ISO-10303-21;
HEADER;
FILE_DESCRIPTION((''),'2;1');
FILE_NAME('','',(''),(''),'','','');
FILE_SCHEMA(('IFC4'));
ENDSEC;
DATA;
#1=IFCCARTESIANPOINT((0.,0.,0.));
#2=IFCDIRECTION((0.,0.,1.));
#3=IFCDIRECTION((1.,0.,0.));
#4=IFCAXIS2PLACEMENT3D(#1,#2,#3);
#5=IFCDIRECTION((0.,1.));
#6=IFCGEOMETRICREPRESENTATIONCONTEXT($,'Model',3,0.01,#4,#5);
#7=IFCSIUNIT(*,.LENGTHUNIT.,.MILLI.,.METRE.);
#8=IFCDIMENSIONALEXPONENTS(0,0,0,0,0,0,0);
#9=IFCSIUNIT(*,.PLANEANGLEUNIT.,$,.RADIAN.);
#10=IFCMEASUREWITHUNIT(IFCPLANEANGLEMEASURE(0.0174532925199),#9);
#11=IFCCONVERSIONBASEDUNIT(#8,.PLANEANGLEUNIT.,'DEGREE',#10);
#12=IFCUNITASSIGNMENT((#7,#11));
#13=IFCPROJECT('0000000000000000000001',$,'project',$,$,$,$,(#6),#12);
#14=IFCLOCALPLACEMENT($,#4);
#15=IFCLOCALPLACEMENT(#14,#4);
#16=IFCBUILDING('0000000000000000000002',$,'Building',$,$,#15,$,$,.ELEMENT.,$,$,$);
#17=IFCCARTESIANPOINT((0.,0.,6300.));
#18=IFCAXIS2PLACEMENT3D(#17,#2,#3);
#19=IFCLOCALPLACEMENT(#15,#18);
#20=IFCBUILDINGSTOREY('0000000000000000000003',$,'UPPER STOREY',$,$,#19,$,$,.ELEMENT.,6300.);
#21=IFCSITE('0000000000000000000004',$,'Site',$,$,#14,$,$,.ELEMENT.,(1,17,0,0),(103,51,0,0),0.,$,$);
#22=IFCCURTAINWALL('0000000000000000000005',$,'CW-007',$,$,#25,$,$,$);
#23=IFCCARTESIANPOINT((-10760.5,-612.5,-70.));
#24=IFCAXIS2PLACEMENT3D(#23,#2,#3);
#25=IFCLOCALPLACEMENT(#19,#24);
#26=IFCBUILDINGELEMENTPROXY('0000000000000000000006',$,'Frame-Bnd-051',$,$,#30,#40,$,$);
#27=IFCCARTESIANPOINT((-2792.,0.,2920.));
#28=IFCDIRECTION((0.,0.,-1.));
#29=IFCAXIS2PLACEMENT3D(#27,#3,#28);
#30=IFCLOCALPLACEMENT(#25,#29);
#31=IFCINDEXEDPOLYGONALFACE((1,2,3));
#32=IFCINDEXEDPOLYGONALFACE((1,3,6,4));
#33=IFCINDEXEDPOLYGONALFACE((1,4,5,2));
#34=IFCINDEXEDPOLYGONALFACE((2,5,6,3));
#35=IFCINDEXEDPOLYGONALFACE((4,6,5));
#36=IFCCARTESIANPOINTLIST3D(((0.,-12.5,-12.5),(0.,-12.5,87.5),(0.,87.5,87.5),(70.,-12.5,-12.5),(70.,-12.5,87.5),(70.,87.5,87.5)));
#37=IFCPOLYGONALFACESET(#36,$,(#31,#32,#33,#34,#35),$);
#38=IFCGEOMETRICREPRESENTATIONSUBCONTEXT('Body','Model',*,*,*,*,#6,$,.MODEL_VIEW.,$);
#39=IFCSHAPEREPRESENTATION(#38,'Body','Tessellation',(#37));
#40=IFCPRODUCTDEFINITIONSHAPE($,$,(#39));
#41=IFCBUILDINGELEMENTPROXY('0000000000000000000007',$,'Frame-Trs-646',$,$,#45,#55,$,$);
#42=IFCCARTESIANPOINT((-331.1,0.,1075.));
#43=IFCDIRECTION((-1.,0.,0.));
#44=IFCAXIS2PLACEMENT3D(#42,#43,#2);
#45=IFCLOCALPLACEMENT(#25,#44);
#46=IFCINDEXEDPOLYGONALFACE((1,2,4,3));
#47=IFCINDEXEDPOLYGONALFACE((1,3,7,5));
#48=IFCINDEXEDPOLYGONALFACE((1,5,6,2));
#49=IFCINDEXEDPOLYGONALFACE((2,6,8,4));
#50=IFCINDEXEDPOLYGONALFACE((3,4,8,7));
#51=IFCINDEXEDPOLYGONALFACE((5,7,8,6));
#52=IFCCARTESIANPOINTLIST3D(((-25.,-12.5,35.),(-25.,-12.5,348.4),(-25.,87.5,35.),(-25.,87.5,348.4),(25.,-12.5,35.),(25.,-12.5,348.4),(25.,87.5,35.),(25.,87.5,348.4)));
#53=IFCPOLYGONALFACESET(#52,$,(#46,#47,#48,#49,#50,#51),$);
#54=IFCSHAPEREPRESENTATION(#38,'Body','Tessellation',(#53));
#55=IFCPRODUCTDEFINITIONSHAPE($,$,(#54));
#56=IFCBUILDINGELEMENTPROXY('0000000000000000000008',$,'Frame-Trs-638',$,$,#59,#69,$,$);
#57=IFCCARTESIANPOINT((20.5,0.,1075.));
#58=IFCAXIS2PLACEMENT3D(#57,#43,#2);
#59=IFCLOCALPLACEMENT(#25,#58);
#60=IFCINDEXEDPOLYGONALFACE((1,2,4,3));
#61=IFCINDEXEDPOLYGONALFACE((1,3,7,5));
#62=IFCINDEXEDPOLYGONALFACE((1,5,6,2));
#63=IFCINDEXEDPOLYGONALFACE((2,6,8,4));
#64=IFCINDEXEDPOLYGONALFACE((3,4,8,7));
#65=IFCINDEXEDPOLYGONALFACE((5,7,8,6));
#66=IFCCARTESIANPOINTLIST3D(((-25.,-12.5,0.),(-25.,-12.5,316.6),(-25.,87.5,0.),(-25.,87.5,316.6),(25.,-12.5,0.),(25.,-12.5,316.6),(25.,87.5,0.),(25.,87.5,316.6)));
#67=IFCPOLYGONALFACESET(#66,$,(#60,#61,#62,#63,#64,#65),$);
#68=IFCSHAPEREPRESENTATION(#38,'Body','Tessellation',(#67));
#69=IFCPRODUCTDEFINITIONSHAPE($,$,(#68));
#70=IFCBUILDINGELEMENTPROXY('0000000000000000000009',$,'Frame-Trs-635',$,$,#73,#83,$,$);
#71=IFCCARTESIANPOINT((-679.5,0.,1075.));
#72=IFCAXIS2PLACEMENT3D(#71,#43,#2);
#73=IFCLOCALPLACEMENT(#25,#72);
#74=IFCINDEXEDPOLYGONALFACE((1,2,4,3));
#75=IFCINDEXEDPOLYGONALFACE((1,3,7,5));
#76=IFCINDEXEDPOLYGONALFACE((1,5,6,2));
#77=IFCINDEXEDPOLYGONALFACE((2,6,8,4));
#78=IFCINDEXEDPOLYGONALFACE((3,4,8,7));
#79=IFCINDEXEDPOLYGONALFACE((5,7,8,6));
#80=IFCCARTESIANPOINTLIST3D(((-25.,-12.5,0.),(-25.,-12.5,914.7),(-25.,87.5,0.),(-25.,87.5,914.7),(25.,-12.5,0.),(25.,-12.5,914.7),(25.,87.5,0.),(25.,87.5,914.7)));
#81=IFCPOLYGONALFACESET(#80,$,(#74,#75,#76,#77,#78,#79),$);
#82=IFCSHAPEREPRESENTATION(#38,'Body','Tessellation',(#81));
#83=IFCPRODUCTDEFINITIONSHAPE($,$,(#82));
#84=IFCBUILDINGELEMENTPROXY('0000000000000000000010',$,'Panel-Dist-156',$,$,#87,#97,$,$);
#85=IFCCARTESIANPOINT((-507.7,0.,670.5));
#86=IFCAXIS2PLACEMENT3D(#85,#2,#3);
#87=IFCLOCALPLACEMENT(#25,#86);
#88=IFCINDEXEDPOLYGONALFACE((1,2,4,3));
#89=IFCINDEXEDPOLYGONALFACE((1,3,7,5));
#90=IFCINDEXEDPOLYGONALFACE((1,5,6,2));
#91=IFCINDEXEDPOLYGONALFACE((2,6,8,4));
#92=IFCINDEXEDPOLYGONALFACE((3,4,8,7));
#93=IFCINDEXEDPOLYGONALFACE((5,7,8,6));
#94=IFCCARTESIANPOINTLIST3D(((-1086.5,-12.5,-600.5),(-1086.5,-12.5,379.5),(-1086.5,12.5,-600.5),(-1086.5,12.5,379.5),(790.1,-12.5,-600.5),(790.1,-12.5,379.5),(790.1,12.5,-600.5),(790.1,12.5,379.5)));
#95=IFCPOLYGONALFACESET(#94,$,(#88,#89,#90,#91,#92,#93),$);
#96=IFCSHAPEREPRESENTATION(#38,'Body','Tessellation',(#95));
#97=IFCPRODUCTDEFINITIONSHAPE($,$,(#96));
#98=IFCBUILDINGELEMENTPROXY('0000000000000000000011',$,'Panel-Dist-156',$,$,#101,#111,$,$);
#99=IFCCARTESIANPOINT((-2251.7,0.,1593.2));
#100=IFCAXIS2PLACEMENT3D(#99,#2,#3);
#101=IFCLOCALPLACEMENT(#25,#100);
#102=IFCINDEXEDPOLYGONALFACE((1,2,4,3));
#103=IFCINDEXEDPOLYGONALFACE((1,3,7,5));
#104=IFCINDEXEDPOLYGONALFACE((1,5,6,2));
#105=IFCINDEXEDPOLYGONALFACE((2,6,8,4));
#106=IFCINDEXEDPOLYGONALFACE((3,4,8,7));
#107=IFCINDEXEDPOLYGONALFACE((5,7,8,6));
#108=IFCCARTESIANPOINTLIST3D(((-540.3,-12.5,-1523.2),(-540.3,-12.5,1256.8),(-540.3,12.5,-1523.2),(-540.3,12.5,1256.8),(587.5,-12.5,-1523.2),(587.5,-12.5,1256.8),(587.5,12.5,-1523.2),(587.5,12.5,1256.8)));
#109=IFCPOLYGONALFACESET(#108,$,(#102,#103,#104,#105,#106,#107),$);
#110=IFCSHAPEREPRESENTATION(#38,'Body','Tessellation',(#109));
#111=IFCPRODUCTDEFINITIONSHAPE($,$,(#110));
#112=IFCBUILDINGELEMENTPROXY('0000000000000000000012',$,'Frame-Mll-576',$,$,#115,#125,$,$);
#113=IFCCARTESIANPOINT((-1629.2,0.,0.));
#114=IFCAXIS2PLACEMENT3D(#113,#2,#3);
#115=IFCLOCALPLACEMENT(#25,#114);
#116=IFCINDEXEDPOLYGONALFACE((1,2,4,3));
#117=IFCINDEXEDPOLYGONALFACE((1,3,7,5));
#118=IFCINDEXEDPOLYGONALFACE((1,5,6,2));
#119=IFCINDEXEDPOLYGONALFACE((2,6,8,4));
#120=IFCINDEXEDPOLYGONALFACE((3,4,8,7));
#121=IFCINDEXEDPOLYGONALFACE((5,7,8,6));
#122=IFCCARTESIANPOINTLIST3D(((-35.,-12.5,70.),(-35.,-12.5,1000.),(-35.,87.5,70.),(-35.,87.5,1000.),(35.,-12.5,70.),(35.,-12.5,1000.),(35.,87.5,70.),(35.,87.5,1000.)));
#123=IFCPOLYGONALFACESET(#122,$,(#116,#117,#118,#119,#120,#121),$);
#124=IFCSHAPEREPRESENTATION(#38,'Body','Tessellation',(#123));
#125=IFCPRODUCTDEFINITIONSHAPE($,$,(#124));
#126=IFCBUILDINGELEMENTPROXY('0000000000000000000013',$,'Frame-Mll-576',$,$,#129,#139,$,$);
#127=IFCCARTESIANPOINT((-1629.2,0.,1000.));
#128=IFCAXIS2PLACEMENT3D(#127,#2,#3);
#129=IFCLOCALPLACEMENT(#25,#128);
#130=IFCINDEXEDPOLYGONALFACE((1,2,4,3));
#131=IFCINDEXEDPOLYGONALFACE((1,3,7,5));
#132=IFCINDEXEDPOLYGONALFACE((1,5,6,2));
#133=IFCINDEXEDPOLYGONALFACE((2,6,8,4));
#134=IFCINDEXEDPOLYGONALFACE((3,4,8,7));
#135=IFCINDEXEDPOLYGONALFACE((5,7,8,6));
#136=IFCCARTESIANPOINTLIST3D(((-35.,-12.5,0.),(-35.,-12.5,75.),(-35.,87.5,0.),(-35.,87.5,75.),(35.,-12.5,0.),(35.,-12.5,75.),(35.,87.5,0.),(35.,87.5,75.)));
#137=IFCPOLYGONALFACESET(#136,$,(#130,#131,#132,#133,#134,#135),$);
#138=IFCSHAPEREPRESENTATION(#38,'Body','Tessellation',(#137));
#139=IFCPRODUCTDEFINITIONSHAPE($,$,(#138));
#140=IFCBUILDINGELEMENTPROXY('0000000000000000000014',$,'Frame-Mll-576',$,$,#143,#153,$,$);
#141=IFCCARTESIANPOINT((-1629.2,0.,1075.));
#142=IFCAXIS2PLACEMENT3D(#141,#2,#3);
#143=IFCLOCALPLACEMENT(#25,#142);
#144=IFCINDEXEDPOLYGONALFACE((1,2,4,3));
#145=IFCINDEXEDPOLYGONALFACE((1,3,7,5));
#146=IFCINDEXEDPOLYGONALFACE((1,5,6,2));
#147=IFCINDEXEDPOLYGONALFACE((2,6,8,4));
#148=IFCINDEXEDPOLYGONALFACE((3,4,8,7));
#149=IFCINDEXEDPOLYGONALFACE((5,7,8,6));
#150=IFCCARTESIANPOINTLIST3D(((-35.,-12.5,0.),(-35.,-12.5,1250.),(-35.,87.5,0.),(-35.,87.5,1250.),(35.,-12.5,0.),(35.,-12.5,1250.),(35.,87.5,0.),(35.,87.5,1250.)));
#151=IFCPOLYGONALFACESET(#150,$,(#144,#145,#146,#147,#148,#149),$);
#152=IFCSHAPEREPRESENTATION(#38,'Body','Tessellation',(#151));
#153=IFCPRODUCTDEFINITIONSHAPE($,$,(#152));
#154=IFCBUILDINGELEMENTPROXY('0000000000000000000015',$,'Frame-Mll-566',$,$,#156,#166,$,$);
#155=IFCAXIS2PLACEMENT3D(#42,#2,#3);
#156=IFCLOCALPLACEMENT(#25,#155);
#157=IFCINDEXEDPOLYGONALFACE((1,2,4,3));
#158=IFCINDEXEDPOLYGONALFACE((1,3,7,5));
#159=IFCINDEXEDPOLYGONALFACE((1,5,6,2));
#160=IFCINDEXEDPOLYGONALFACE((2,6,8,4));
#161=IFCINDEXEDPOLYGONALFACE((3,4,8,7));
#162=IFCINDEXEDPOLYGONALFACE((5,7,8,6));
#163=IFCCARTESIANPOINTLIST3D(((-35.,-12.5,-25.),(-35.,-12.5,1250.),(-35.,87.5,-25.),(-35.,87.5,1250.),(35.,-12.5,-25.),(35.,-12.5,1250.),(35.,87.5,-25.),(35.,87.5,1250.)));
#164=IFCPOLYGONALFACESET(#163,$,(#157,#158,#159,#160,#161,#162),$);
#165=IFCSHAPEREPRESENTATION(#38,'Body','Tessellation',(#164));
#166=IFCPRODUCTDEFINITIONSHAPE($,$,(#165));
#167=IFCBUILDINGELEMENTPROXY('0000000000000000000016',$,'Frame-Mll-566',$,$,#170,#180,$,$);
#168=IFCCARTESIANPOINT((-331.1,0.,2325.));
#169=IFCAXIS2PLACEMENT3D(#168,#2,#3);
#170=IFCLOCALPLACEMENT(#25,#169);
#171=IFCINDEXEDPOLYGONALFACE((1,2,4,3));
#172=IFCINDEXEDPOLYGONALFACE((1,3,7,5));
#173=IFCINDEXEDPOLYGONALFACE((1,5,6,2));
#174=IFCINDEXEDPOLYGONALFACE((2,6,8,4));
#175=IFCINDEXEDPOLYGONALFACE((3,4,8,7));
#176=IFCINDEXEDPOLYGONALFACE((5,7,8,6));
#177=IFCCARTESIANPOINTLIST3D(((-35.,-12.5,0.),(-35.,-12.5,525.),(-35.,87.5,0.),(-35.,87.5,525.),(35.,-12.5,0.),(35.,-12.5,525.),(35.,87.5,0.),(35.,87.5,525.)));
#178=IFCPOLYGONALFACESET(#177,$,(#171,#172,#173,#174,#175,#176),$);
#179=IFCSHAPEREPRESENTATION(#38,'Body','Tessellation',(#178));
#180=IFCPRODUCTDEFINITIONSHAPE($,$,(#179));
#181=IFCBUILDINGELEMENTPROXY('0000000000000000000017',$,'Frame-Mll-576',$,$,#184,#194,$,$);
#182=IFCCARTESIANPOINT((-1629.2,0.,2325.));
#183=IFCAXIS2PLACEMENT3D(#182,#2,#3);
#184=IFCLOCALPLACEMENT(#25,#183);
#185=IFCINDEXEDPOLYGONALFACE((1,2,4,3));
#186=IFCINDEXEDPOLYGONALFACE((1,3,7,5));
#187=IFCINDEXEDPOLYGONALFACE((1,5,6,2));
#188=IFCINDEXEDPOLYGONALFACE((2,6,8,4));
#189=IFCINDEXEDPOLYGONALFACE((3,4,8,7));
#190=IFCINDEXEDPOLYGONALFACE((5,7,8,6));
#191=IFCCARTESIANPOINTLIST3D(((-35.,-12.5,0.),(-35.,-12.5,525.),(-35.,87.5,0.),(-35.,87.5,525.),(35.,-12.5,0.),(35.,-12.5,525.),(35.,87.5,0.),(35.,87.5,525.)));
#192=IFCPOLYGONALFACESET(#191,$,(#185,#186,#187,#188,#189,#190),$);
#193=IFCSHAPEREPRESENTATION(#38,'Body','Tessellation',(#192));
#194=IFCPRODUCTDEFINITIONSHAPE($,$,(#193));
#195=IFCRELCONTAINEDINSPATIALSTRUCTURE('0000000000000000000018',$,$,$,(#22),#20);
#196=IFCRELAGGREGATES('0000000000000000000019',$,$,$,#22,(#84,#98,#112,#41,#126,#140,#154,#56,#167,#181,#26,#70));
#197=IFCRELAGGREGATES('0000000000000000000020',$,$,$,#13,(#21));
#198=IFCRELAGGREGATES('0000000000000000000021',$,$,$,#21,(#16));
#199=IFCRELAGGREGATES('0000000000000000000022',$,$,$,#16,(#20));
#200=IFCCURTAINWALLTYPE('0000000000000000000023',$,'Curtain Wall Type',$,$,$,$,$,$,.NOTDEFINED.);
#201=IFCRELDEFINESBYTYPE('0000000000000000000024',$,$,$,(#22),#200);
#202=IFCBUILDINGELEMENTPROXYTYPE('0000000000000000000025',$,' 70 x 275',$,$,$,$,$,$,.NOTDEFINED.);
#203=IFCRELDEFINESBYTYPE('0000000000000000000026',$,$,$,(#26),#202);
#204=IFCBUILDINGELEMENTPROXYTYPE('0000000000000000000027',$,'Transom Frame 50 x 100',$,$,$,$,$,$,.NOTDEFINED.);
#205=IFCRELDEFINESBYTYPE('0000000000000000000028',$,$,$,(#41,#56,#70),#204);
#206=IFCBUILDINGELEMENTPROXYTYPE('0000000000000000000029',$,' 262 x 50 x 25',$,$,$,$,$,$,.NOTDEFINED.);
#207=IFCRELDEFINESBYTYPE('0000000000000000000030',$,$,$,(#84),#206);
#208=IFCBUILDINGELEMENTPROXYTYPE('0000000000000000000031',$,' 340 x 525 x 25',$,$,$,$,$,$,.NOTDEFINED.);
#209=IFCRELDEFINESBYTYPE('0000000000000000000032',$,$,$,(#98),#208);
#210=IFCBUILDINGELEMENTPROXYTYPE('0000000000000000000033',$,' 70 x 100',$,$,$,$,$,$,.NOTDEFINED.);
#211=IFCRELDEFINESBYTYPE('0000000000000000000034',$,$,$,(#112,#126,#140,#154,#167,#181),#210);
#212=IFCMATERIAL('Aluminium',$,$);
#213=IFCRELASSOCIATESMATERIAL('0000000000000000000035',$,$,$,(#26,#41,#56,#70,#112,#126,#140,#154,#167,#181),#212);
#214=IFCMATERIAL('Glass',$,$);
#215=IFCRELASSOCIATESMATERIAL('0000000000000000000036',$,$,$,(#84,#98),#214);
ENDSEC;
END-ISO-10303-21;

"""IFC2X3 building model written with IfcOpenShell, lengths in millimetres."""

from ifc_helpers import new_model, entity, si_unit, converted_unit, direction, frame, origin_with_axes, place, context, subcontext, project, spatial, polyline, outline, extrude, clip, halfspace, material, type_object, element, aggregate, save


model = new_model("IFC2X3")

# Units and contexts
model_context = context("Model", 3, precision=0.01, world=origin_with_axes(), true_north=direction((0.0, 1.0)))
body_context = subcontext(model_context, "Body", "Model", "MODEL_VIEW")
ifc_project = project(units=[si_unit("LENGTHUNIT", "METRE", prefix="MILLI"), converted_unit("PLANEANGLEUNIT", "DEGREE", entity("IfcPlaneAngleMeasure", 0.0174532925199), si_unit("PLANEANGLEUNIT", "RADIAN"), dimensions=[0, 0, 0, 0, 0, 0, 0])], contexts=[model_context])

# Site, building, storey
site_placement = place(None, origin_with_axes())
site = spatial("IfcSite", under=ifc_project, at=site_placement, Name="Site", CompositionType="ELEMENT", RefLatitude=(1, 17, 0, 0), RefLongitude=(103, 51, 0, 0), RefElevation=0.0)
building_placement = place(site_placement, origin_with_axes())
building = spatial("IfcBuilding", under=site, at=building_placement, Name="Building", CompositionType="ELEMENT")
storey_placement = place(building_placement, frame((0.0, 0.0, 6300.0), z_axis=(0.0, 0.0, 1.0), x_axis=(1.0, 0.0, 0.0)))
storey = spatial("IfcBuildingStorey", under=building, at=storey_placement, Name="UPPER STOREY", CompositionType="ELEMENT", Elevation=6300.0)

# Curtain wall, building element proxies
curtain_wall_type = type_object("IfcCurtainWallType", Name="Curtain Wall Type", PredefinedType="NOTDEFINED")
curtain_wall_placement = place(storey_placement, frame((-10760.5, -612.5, -70.0), z_axis=(0.0, 0.0, 1.0), x_axis=(1.0, 0.0, 0.0)))
curtain_wall = element("IfcCurtainWall", 1, at=curtain_wall_placement, inside=storey, type_object=curtain_wall_type, Name="CW-007")
ifc_material_1 = material(Name="Aluminium")
building_element_proxy_type_1 = type_object("IfcBuildingElementProxyType", Name=" 70 x 275", PredefinedType="NOTDEFINED")
proxy_1_placement = place(curtain_wall_placement, frame((-2792.0, 0.0, 2920.0), z_axis=(1.0, 0.0, 0.0), x_axis=(0.0, 0.0, -1.0)))
proxy_1 = element("IfcBuildingElementProxy", 2, at=proxy_1_placement, type_object=building_element_proxy_type_1, material=ifc_material_1, Name="Frame-Bnd-051", context=body_context, shape_type="Clipping", body=[
    clip(extrude(outline(polyline([(-87.5, 70.0), (-87.5, 0.0), (12.5, 0.0), (12.5, 70.0), (-87.5, 70.0)])), frame((0.0, 0.0, -12.5), z_axis=(0.0, 0.0, 1.0), x_axis=(0.0, -1.0, 0.0)), (0.0, 0.0, 1.0), 100.0), halfspace(frame((0.0, 0.0, 0.0), z_axis=(0.0, -0.707107, 0.707107), x_axis=(0.0, -0.707107, -0.707107)), True)),
])
building_element_proxy_type_2 = type_object("IfcBuildingElementProxyType", Name="Transom Frame 50 x 100", PredefinedType="NOTDEFINED")
proxy_2_placement = place(curtain_wall_placement, frame((-331.1, 0.0, 1075.0), z_axis=(-1.0, 0.0, 0.0), x_axis=(0.0, 0.0, 1.0)))
proxy_2 = element("IfcBuildingElementProxy", 3, at=proxy_2_placement, type_object=building_element_proxy_type_2, material=ifc_material_1, Name="Frame-Trs-646", context=body_context, shape_type="SweptSolid", body=[
    extrude(outline(polyline([(87.5, -25.0), (87.5, 25.0), (-12.5, 25.0), (-12.5, -25.0), (87.5, -25.0)])), frame((0.0, 0.0, 35.0), z_axis=(0.0, 0.0, 1.0), x_axis=(0.0, 1.0, 0.0)), (0.0, 0.0, 1.0), 313.4),
])
proxy_3_placement = place(curtain_wall_placement, frame((20.5, 0.0, 1075.0), z_axis=(-1.0, 0.0, 0.0), x_axis=(0.0, 0.0, 1.0)))
proxy_3 = element("IfcBuildingElementProxy", 4, at=proxy_3_placement, type_object=building_element_proxy_type_2, material=ifc_material_1, Name="Frame-Trs-638", context=body_context, shape_type="SweptSolid", body=[
    extrude(outline(polyline([(87.5, -25.0), (87.5, 25.0), (-12.5, 25.0), (-12.5, -25.0), (87.5, -25.0)])), frame((0.0, 0.0, 0.0), z_axis=(0.0, 0.0, 1.0), x_axis=(0.0, 1.0, 0.0)), (0.0, 0.0, 1.0), 316.6),
])
proxy_4_placement = place(curtain_wall_placement, frame((-679.5, 0.0, 1075.0), z_axis=(-1.0, 0.0, 0.0), x_axis=(0.0, 0.0, 1.0)))
proxy_4 = element("IfcBuildingElementProxy", 5, at=proxy_4_placement, type_object=building_element_proxy_type_2, material=ifc_material_1, Name="Frame-Trs-635", context=body_context, shape_type="SweptSolid", body=[
    extrude(outline(polyline([(87.5, -25.0), (87.5, 25.0), (-12.5, 25.0), (-12.5, -25.0), (87.5, -25.0)])), frame((0.0, 0.0, 0.0), z_axis=(0.0, 0.0, 1.0), x_axis=(0.0, 1.0, 0.0)), (0.0, 0.0, 1.0), 914.7),
])
ifc_material_2 = material(Name="Glass")
building_element_proxy_type_3 = type_object("IfcBuildingElementProxyType", Name=" 262 x 50 x 25", PredefinedType="NOTDEFINED")
proxy_5_placement = place(curtain_wall_placement, frame((-507.7, 0.0, 670.5), z_axis=(0.0, 0.0, 1.0), x_axis=(1.0, 0.0, 0.0)))
proxy_5 = element("IfcBuildingElementProxy", 6, at=proxy_5_placement, type_object=building_element_proxy_type_3, material=ifc_material_2, Name="Panel-Dist-156", context=body_context, shape_type="SweptSolid", body=[
    extrude(outline(polyline([(-1086.5, -379.5), (790.1, -379.5), (790.1, 600.5), (-1086.5, 600.5), (-1086.5, -379.5)])), frame((0.0, -12.5, 0.0), z_axis=(0.0, 1.0, 0.0), x_axis=(1.0, 0.0, 0.0)), (0.0, 0.0, 1.0), 25.0),
])
building_element_proxy_type_4 = type_object("IfcBuildingElementProxyType", Name=" 340 x 525 x 25", PredefinedType="NOTDEFINED")
proxy_6_placement = place(curtain_wall_placement, frame((-2251.7, 0.0, 1593.2), z_axis=(0.0, 0.0, 1.0), x_axis=(1.0, 0.0, 0.0)))
proxy_6 = element("IfcBuildingElementProxy", 7, at=proxy_6_placement, type_object=building_element_proxy_type_4, material=ifc_material_2, Name="Panel-Dist-156", context=body_context, shape_type="SweptSolid", body=[
    extrude(outline(polyline([(-540.3, -1256.8), (587.5, -1256.8), (587.5, 1523.2), (-540.3, 1523.2), (-540.3, -1256.8)])), frame((0.0, -12.5, 0.0), z_axis=(0.0, 1.0, 0.0), x_axis=(1.0, 0.0, 0.0)), (0.0, 0.0, 1.0), 25.0),
])
building_element_proxy_type_5 = type_object("IfcBuildingElementProxyType", Name=" 70 x 100", PredefinedType="NOTDEFINED")
proxy_7_placement = place(curtain_wall_placement, frame((-1629.2, 0.0, 0.0), z_axis=(0.0, 0.0, 1.0), x_axis=(1.0, 0.0, 0.0)))
proxy_7 = element("IfcBuildingElementProxy", 8, at=proxy_7_placement, type_object=building_element_proxy_type_5, material=ifc_material_1, Name="Frame-Mll-576", context=body_context, shape_type="SweptSolid", body=[
    extrude(outline(polyline([(35.0, 87.5), (-35.0, 87.5), (-35.0, -12.5), (35.0, -12.5), (35.0, 87.5)])), frame((0.0, 0.0, 70.0), z_axis=(0.0, 0.0, 1.0), x_axis=(1.0, 0.0, 0.0)), (0.0, 0.0, 1.0), 930.0),
])
proxy_8_placement = place(curtain_wall_placement, frame((-1629.2, 0.0, 1000.0), z_axis=(0.0, 0.0, 1.0), x_axis=(1.0, 0.0, 0.0)))
proxy_8 = element("IfcBuildingElementProxy", 9, at=proxy_8_placement, type_object=building_element_proxy_type_5, material=ifc_material_1, Name="Frame-Mll-576", context=body_context, shape_type="SweptSolid", body=[
    extrude(outline(polyline([(35.0, 87.5), (-35.0, 87.5), (-35.0, -12.5), (35.0, -12.5), (35.0, 87.5)])), frame((0.0, 0.0, 0.0), z_axis=(0.0, 0.0, 1.0), x_axis=(1.0, 0.0, 0.0)), (0.0, 0.0, 1.0), 75.0),
])
proxy_9_placement = place(curtain_wall_placement, frame((-1629.2, 0.0, 1075.0), z_axis=(0.0, 0.0, 1.0), x_axis=(1.0, 0.0, 0.0)))
proxy_9 = element("IfcBuildingElementProxy", 10, at=proxy_9_placement, type_object=building_element_proxy_type_5, material=ifc_material_1, Name="Frame-Mll-576", context=body_context, shape_type="SweptSolid", body=[
    extrude(outline(polyline([(35.0, 87.5), (-35.0, 87.5), (-35.0, -12.5), (35.0, -12.5), (35.0, 87.5)])), frame((0.0, 0.0, 0.0), z_axis=(0.0, 0.0, 1.0), x_axis=(1.0, 0.0, 0.0)), (0.0, 0.0, 1.0), 1250.0),
])
proxy_10_placement = place(curtain_wall_placement, frame((-331.1, 0.0, 1075.0), z_axis=(0.0, 0.0, 1.0), x_axis=(1.0, 0.0, 0.0)))
proxy_10 = element("IfcBuildingElementProxy", 11, at=proxy_10_placement, type_object=building_element_proxy_type_5, material=ifc_material_1, Name="Frame-Mll-566", context=body_context, shape_type="SweptSolid", body=[
    extrude(outline(polyline([(35.0, 87.5), (-35.0, 87.5), (-35.0, -12.5), (35.0, -12.5), (35.0, 87.5)])), frame((0.0, 0.0, -25.0), z_axis=(0.0, 0.0, 1.0), x_axis=(1.0, 0.0, 0.0)), (0.0, 0.0, 1.0), 1275.0),
])
proxy_11_placement = place(curtain_wall_placement, frame((-331.1, 0.0, 2325.0), z_axis=(0.0, 0.0, 1.0), x_axis=(1.0, 0.0, 0.0)))
proxy_11 = element("IfcBuildingElementProxy", 12, at=proxy_11_placement, type_object=building_element_proxy_type_5, material=ifc_material_1, Name="Frame-Mll-566", context=body_context, shape_type="SweptSolid", body=[
    extrude(outline(polyline([(35.0, 87.5), (-35.0, 87.5), (-35.0, -12.5), (35.0, -12.5), (35.0, 87.5)])), frame((0.0, 0.0, 0.0), z_axis=(0.0, 0.0, 1.0), x_axis=(1.0, 0.0, 0.0)), (0.0, 0.0, 1.0), 525.0),
])
proxy_12_placement = place(curtain_wall_placement, frame((-1629.2, 0.0, 2325.0), z_axis=(0.0, 0.0, 1.0), x_axis=(1.0, 0.0, 0.0)))
proxy_12 = element("IfcBuildingElementProxy", 13, at=proxy_12_placement, type_object=building_element_proxy_type_5, material=ifc_material_1, Name="Frame-Mll-576", context=body_context, shape_type="SweptSolid", body=[
    extrude(outline(polyline([(35.0, 87.5), (-35.0, 87.5), (-35.0, -12.5), (35.0, -12.5), (35.0, 87.5)])), frame((0.0, 0.0, 0.0), z_axis=(0.0, 0.0, 1.0), x_axis=(1.0, 0.0, 0.0)), (0.0, 0.0, 1.0), 525.0),
])
aggregate(curtain_wall, [proxy_5, proxy_6, proxy_7, proxy_2, proxy_8, proxy_9, proxy_10, proxy_3, proxy_11, proxy_12, proxy_1, proxy_4])

save(model, "model.ifc")
